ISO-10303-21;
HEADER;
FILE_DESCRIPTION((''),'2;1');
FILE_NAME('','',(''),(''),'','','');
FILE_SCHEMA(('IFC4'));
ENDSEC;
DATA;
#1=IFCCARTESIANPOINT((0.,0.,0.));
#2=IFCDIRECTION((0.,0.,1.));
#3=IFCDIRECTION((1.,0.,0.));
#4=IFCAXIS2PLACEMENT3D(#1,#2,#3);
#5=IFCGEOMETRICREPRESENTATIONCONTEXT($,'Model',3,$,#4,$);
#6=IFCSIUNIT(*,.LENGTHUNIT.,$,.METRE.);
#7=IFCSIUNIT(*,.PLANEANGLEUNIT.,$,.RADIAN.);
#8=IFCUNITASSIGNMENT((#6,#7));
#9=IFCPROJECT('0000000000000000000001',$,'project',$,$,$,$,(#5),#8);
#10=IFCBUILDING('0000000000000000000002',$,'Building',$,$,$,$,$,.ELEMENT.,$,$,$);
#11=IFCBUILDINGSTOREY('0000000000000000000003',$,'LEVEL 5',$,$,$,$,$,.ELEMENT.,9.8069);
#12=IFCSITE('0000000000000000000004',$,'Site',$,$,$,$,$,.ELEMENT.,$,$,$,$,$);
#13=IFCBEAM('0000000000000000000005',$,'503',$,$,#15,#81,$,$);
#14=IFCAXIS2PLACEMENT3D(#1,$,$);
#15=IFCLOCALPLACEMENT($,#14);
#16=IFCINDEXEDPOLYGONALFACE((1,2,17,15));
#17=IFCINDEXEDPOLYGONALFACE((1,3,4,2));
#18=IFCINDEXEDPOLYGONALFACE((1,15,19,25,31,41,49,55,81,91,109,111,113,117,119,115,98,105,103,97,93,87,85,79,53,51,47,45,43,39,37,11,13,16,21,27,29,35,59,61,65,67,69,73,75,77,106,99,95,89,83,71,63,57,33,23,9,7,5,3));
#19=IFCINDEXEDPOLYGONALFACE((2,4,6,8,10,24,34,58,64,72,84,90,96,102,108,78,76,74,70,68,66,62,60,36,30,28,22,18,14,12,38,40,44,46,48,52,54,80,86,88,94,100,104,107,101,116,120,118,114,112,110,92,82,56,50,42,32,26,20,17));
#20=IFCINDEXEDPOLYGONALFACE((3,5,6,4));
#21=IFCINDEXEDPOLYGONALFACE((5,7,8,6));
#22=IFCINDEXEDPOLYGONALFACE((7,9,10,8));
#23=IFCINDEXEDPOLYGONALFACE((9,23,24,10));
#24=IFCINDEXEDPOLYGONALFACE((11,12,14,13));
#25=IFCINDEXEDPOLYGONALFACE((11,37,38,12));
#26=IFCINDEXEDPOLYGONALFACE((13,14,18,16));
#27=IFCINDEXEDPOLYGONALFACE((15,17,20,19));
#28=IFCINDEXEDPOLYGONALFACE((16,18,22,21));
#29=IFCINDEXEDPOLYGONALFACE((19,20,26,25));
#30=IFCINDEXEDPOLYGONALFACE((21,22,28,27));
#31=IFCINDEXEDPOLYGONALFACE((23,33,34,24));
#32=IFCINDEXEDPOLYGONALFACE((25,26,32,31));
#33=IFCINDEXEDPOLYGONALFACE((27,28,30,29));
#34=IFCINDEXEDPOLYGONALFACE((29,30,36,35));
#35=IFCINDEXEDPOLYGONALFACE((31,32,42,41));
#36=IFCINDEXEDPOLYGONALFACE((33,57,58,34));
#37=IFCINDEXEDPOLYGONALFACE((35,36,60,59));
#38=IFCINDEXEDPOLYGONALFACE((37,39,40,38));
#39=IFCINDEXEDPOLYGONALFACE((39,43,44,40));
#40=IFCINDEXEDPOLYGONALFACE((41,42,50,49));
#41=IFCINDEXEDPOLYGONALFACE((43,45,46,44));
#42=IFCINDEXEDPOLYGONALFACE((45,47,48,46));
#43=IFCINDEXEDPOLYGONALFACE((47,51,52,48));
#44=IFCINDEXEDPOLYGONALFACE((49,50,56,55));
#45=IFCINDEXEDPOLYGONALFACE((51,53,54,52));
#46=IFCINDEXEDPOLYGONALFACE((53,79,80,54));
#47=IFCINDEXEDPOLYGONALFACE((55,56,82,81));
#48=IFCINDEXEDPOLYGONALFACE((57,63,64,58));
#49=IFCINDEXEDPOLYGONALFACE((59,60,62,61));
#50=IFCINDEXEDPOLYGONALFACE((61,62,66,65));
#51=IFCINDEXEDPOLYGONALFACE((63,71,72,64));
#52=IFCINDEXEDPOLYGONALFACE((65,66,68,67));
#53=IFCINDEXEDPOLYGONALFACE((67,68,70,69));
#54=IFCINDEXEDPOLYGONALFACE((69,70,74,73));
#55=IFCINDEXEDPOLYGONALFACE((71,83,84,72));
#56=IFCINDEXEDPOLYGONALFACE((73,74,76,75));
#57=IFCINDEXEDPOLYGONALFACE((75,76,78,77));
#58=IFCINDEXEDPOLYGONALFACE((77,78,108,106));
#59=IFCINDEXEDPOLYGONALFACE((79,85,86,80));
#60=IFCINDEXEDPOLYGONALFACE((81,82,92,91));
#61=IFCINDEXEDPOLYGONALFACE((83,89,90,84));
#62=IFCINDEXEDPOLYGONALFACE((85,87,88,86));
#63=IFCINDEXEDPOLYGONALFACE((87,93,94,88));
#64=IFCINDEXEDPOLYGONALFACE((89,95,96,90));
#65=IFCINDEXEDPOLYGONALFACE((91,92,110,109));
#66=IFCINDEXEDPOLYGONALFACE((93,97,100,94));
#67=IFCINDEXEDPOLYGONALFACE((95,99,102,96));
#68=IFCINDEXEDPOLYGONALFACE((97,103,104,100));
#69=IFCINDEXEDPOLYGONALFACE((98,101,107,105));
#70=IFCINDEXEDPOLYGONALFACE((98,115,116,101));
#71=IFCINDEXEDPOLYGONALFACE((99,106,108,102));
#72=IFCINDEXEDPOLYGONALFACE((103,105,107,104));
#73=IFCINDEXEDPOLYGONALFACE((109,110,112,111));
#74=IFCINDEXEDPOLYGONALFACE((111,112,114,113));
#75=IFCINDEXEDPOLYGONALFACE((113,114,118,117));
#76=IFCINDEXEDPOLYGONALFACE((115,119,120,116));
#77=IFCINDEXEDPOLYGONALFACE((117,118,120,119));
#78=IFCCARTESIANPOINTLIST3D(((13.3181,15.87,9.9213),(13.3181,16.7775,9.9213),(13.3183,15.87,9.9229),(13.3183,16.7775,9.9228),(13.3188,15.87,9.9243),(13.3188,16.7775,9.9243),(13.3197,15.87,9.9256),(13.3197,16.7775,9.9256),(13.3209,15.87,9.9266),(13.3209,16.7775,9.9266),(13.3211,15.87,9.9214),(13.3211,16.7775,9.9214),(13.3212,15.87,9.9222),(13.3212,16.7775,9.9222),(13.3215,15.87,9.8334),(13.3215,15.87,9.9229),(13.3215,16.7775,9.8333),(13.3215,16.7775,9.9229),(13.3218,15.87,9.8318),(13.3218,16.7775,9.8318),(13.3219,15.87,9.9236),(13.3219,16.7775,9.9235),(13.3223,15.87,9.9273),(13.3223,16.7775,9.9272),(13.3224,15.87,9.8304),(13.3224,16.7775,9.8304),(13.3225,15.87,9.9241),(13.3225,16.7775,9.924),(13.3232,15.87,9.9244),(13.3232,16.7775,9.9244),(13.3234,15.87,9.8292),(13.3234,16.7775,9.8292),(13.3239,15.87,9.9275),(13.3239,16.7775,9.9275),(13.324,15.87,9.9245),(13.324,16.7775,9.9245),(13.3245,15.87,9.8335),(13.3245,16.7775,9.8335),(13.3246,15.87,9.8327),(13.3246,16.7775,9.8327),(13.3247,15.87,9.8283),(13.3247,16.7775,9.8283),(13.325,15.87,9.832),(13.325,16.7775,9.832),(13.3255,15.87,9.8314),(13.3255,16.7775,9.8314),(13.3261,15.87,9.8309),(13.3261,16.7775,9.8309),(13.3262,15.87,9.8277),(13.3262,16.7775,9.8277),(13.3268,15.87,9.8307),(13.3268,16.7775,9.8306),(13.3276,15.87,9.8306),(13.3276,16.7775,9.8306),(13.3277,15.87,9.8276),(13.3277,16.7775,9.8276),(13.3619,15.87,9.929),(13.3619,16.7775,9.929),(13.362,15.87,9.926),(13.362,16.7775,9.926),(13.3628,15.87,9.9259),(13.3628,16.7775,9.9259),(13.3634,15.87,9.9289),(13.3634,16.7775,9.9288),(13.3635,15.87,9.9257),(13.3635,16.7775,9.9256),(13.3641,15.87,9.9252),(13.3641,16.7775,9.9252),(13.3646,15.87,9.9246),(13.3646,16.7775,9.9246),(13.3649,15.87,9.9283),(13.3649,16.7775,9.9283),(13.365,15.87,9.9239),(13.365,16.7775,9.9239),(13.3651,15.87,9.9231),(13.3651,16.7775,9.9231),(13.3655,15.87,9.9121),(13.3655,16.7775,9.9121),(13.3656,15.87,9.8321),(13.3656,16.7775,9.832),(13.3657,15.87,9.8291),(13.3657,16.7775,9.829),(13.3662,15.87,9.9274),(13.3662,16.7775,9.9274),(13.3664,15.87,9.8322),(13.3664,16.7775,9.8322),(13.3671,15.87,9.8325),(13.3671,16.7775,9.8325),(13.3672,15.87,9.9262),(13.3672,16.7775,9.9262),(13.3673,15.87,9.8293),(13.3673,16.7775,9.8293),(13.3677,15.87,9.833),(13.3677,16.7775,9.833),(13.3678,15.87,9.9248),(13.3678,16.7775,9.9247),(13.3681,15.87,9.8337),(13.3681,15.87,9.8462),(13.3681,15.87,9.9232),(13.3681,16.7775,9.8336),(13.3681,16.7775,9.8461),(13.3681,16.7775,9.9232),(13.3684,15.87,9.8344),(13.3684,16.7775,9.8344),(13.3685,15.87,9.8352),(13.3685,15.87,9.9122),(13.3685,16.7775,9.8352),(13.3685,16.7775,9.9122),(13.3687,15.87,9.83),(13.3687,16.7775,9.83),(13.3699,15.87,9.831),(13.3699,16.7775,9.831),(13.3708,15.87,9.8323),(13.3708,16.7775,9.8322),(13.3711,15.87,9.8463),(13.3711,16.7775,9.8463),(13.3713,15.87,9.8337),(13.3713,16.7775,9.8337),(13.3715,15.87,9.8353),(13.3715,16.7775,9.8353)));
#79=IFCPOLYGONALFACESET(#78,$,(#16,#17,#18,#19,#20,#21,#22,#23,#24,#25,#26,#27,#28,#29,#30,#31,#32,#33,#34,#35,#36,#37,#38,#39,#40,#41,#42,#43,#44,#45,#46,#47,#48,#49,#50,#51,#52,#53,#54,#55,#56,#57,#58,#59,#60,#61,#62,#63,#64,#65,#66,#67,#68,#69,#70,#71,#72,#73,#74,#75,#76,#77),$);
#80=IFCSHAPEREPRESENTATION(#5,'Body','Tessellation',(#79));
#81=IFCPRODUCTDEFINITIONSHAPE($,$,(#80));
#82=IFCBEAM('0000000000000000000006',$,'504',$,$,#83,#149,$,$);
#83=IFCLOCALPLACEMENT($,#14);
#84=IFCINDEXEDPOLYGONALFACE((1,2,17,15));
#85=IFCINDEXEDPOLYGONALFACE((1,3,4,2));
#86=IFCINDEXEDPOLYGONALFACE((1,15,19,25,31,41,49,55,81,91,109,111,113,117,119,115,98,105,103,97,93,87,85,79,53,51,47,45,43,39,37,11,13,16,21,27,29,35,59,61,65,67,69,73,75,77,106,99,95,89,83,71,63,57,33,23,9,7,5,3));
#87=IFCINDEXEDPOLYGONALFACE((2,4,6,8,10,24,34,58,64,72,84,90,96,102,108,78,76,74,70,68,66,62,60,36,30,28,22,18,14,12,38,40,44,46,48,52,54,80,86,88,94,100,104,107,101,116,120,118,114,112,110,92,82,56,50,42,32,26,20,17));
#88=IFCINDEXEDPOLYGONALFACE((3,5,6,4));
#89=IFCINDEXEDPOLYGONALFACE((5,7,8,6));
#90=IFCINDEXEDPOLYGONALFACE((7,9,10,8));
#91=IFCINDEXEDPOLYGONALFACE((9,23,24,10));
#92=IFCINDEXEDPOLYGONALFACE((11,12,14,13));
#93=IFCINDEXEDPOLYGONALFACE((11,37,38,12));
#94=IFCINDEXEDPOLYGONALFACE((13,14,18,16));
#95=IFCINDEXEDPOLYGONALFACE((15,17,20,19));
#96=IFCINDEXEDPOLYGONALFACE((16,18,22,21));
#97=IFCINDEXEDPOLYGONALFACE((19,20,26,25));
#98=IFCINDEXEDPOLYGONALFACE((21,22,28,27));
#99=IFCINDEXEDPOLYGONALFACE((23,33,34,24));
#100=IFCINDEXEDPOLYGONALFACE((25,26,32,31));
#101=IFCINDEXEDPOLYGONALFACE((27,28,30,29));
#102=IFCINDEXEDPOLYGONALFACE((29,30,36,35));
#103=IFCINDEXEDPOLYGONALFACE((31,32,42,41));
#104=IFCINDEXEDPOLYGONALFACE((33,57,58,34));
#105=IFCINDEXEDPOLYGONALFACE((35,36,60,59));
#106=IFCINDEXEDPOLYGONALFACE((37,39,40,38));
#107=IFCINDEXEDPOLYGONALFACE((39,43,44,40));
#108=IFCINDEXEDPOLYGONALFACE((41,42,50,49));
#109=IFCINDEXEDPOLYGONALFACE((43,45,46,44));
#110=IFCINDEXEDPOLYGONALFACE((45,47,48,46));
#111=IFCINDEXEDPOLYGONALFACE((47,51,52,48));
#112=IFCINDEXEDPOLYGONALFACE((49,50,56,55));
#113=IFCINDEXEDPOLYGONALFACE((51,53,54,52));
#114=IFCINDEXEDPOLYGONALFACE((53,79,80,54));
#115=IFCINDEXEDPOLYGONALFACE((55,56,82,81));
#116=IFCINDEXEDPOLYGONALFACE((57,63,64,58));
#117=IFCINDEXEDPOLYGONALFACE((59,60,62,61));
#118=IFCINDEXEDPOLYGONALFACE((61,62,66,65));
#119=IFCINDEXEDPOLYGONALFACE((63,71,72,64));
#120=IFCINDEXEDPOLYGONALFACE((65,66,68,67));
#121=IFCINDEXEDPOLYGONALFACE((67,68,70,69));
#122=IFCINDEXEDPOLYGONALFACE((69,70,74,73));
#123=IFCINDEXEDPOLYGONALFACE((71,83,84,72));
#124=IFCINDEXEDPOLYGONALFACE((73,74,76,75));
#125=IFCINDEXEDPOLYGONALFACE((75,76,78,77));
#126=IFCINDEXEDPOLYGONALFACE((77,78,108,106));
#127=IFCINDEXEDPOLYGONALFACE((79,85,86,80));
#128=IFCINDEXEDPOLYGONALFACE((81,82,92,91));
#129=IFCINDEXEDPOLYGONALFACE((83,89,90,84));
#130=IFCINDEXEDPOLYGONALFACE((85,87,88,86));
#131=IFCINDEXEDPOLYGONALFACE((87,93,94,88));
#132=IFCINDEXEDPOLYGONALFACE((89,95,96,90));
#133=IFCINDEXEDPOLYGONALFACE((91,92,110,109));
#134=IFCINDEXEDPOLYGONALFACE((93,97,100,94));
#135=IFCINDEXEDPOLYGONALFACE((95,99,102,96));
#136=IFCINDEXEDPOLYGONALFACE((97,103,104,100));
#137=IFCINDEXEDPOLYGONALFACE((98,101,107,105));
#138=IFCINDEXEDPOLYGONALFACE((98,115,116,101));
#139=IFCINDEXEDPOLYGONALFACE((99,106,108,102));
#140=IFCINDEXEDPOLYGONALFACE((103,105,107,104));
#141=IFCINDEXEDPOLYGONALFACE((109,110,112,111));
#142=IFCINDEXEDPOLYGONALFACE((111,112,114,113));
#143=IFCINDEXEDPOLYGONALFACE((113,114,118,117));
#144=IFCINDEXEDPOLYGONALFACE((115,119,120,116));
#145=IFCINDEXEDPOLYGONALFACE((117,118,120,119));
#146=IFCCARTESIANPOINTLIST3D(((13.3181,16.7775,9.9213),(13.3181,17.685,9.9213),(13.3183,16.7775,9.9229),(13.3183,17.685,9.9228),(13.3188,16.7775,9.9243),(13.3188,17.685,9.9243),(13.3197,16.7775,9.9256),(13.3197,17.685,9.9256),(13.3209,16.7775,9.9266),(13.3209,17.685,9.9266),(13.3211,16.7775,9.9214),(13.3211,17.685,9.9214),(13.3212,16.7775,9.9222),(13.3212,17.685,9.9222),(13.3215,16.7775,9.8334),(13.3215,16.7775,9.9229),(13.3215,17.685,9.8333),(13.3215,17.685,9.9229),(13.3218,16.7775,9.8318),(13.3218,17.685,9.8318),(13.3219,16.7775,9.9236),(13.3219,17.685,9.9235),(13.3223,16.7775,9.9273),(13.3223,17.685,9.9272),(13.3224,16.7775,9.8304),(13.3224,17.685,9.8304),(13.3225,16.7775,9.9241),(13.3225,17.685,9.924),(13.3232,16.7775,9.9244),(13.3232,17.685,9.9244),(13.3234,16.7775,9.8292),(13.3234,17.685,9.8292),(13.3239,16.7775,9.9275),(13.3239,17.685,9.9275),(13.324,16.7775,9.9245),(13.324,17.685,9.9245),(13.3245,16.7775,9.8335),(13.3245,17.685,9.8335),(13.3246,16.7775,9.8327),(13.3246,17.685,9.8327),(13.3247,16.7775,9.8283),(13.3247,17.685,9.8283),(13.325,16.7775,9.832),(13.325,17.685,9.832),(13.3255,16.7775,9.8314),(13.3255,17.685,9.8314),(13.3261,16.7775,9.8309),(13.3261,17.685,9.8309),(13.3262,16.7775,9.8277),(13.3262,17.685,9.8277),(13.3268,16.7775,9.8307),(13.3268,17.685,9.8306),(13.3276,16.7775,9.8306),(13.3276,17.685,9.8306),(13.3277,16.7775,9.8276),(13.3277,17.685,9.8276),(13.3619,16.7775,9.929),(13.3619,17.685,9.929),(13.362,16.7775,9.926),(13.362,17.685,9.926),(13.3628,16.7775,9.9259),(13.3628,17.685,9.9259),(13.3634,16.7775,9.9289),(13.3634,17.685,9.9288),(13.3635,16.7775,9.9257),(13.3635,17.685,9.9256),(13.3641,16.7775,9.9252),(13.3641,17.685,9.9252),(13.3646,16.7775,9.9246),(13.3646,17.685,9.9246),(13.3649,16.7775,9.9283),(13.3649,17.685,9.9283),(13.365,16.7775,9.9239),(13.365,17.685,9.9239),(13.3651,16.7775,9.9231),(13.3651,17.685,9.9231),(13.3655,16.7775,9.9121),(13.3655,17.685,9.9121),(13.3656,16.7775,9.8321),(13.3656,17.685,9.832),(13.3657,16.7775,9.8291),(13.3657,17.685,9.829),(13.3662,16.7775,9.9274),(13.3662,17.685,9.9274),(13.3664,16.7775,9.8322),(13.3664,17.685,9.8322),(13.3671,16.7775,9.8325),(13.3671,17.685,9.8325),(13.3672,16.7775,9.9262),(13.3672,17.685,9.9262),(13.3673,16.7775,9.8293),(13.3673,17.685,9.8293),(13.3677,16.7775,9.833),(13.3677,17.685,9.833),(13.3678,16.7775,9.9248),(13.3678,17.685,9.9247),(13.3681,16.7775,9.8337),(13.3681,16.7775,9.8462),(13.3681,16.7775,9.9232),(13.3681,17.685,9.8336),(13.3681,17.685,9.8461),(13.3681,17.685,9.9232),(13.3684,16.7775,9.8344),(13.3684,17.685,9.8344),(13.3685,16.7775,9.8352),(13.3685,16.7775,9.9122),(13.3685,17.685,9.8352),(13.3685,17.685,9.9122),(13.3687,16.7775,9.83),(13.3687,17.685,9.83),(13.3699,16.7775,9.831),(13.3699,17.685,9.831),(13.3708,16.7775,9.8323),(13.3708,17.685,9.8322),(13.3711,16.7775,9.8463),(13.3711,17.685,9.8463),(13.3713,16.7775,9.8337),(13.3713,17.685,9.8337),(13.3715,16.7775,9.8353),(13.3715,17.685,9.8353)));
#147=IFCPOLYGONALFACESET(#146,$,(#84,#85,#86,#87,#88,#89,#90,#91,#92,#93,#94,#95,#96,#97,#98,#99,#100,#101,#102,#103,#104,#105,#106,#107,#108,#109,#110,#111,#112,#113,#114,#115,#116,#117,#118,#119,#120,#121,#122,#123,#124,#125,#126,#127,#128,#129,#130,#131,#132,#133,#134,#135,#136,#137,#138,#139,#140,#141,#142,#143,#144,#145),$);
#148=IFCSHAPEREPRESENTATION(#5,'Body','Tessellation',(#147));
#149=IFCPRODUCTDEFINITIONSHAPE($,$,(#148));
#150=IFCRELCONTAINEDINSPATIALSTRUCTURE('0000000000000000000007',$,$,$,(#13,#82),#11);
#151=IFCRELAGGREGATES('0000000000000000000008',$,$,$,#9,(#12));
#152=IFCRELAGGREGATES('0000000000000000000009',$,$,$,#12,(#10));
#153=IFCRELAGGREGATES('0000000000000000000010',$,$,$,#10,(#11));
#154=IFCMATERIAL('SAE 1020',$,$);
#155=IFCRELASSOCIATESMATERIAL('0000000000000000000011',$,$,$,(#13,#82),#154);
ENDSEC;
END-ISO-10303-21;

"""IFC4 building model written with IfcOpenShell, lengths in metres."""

from ifc_helpers import new_model, si_unit, frame, origin_with_axes, origin_2d_with_axis, place, context, project, spatial, c_section, extrude, material, material_profile, profile_set, profile_usage, element, save


model = new_model("IFC4")

# Units and contexts
model_context = context("Model", 3, world=origin_with_axes())
ifc_project = project(units=[si_unit("LENGTHUNIT", "METRE"), si_unit("PLANEANGLEUNIT", "RADIAN")], contexts=[model_context])

# Site, building, storey
site = spatial("IfcSite", under=ifc_project, Name="Site", CompositionType="ELEMENT")
building = spatial("IfcBuilding", under=site, Name="Building", CompositionType="ELEMENT")
storey = spatial("IfcBuildingStorey", under=building, Name="LEVEL 5", CompositionType="ELEMENT", Elevation=9.8069)

# Beams
ifc_material = material(Name="SAE 1020")
ifc_material_profile_1 = material_profile(ifc_material, c_section(Depth=0.1, Width=0.05, WallThickness=0.003, Girth=0.017, InternalFilletRadius=0.003, at=origin_2d_with_axis()))
ifc_profile_set_1 = profile_set([ifc_material_profile_1])
ifc_profile_usage_1 = profile_usage(ifc_profile_set_1, cardinal=10)
beam_1_placement = place(None, frame((13.3448, 15.87, 9.8783), z_axis=(0.0, 1.0, -0.00003), x_axis=(0.999256, 0.000001, 0.038562)))
element("IfcBeam", 1, at=beam_1_placement, inside=storey, material=ifc_profile_usage_1, Name="503", context=model_context, shape_type="SweptSolid", body=[
    extrude(c_section(Depth=0.1, Width=0.05, WallThickness=0.003, Girth=0.017, InternalFilletRadius=0.003, at=origin_2d_with_axis()), origin_with_axes(), (0.0, 0.0, 1.0), 0.9075),
])
ifc_material_profile_2 = material_profile(ifc_material, c_section(Depth=0.1, Width=0.05, WallThickness=0.003, Girth=0.017, InternalFilletRadius=0.003, at=origin_2d_with_axis()))
ifc_profile_set_2 = profile_set([ifc_material_profile_2])
ifc_profile_usage_2 = profile_usage(ifc_profile_set_2, cardinal=10)
beam_2_placement = place(None, frame((13.3448, 16.7775, 9.8783), z_axis=(0.0, 1.0, -0.00003), x_axis=(0.999256, 0.000001, 0.038562)))
element("IfcBeam", 2, at=beam_2_placement, inside=storey, material=ifc_profile_usage_2, Name="504", context=model_context, shape_type="SweptSolid", body=[
    extrude(c_section(Depth=0.1, Width=0.05, WallThickness=0.003, Girth=0.017, InternalFilletRadius=0.003, at=origin_2d_with_axis()), origin_with_axes(), (0.0, 0.0, 1.0), 0.9075),
])

save(model, "model.ifc")
